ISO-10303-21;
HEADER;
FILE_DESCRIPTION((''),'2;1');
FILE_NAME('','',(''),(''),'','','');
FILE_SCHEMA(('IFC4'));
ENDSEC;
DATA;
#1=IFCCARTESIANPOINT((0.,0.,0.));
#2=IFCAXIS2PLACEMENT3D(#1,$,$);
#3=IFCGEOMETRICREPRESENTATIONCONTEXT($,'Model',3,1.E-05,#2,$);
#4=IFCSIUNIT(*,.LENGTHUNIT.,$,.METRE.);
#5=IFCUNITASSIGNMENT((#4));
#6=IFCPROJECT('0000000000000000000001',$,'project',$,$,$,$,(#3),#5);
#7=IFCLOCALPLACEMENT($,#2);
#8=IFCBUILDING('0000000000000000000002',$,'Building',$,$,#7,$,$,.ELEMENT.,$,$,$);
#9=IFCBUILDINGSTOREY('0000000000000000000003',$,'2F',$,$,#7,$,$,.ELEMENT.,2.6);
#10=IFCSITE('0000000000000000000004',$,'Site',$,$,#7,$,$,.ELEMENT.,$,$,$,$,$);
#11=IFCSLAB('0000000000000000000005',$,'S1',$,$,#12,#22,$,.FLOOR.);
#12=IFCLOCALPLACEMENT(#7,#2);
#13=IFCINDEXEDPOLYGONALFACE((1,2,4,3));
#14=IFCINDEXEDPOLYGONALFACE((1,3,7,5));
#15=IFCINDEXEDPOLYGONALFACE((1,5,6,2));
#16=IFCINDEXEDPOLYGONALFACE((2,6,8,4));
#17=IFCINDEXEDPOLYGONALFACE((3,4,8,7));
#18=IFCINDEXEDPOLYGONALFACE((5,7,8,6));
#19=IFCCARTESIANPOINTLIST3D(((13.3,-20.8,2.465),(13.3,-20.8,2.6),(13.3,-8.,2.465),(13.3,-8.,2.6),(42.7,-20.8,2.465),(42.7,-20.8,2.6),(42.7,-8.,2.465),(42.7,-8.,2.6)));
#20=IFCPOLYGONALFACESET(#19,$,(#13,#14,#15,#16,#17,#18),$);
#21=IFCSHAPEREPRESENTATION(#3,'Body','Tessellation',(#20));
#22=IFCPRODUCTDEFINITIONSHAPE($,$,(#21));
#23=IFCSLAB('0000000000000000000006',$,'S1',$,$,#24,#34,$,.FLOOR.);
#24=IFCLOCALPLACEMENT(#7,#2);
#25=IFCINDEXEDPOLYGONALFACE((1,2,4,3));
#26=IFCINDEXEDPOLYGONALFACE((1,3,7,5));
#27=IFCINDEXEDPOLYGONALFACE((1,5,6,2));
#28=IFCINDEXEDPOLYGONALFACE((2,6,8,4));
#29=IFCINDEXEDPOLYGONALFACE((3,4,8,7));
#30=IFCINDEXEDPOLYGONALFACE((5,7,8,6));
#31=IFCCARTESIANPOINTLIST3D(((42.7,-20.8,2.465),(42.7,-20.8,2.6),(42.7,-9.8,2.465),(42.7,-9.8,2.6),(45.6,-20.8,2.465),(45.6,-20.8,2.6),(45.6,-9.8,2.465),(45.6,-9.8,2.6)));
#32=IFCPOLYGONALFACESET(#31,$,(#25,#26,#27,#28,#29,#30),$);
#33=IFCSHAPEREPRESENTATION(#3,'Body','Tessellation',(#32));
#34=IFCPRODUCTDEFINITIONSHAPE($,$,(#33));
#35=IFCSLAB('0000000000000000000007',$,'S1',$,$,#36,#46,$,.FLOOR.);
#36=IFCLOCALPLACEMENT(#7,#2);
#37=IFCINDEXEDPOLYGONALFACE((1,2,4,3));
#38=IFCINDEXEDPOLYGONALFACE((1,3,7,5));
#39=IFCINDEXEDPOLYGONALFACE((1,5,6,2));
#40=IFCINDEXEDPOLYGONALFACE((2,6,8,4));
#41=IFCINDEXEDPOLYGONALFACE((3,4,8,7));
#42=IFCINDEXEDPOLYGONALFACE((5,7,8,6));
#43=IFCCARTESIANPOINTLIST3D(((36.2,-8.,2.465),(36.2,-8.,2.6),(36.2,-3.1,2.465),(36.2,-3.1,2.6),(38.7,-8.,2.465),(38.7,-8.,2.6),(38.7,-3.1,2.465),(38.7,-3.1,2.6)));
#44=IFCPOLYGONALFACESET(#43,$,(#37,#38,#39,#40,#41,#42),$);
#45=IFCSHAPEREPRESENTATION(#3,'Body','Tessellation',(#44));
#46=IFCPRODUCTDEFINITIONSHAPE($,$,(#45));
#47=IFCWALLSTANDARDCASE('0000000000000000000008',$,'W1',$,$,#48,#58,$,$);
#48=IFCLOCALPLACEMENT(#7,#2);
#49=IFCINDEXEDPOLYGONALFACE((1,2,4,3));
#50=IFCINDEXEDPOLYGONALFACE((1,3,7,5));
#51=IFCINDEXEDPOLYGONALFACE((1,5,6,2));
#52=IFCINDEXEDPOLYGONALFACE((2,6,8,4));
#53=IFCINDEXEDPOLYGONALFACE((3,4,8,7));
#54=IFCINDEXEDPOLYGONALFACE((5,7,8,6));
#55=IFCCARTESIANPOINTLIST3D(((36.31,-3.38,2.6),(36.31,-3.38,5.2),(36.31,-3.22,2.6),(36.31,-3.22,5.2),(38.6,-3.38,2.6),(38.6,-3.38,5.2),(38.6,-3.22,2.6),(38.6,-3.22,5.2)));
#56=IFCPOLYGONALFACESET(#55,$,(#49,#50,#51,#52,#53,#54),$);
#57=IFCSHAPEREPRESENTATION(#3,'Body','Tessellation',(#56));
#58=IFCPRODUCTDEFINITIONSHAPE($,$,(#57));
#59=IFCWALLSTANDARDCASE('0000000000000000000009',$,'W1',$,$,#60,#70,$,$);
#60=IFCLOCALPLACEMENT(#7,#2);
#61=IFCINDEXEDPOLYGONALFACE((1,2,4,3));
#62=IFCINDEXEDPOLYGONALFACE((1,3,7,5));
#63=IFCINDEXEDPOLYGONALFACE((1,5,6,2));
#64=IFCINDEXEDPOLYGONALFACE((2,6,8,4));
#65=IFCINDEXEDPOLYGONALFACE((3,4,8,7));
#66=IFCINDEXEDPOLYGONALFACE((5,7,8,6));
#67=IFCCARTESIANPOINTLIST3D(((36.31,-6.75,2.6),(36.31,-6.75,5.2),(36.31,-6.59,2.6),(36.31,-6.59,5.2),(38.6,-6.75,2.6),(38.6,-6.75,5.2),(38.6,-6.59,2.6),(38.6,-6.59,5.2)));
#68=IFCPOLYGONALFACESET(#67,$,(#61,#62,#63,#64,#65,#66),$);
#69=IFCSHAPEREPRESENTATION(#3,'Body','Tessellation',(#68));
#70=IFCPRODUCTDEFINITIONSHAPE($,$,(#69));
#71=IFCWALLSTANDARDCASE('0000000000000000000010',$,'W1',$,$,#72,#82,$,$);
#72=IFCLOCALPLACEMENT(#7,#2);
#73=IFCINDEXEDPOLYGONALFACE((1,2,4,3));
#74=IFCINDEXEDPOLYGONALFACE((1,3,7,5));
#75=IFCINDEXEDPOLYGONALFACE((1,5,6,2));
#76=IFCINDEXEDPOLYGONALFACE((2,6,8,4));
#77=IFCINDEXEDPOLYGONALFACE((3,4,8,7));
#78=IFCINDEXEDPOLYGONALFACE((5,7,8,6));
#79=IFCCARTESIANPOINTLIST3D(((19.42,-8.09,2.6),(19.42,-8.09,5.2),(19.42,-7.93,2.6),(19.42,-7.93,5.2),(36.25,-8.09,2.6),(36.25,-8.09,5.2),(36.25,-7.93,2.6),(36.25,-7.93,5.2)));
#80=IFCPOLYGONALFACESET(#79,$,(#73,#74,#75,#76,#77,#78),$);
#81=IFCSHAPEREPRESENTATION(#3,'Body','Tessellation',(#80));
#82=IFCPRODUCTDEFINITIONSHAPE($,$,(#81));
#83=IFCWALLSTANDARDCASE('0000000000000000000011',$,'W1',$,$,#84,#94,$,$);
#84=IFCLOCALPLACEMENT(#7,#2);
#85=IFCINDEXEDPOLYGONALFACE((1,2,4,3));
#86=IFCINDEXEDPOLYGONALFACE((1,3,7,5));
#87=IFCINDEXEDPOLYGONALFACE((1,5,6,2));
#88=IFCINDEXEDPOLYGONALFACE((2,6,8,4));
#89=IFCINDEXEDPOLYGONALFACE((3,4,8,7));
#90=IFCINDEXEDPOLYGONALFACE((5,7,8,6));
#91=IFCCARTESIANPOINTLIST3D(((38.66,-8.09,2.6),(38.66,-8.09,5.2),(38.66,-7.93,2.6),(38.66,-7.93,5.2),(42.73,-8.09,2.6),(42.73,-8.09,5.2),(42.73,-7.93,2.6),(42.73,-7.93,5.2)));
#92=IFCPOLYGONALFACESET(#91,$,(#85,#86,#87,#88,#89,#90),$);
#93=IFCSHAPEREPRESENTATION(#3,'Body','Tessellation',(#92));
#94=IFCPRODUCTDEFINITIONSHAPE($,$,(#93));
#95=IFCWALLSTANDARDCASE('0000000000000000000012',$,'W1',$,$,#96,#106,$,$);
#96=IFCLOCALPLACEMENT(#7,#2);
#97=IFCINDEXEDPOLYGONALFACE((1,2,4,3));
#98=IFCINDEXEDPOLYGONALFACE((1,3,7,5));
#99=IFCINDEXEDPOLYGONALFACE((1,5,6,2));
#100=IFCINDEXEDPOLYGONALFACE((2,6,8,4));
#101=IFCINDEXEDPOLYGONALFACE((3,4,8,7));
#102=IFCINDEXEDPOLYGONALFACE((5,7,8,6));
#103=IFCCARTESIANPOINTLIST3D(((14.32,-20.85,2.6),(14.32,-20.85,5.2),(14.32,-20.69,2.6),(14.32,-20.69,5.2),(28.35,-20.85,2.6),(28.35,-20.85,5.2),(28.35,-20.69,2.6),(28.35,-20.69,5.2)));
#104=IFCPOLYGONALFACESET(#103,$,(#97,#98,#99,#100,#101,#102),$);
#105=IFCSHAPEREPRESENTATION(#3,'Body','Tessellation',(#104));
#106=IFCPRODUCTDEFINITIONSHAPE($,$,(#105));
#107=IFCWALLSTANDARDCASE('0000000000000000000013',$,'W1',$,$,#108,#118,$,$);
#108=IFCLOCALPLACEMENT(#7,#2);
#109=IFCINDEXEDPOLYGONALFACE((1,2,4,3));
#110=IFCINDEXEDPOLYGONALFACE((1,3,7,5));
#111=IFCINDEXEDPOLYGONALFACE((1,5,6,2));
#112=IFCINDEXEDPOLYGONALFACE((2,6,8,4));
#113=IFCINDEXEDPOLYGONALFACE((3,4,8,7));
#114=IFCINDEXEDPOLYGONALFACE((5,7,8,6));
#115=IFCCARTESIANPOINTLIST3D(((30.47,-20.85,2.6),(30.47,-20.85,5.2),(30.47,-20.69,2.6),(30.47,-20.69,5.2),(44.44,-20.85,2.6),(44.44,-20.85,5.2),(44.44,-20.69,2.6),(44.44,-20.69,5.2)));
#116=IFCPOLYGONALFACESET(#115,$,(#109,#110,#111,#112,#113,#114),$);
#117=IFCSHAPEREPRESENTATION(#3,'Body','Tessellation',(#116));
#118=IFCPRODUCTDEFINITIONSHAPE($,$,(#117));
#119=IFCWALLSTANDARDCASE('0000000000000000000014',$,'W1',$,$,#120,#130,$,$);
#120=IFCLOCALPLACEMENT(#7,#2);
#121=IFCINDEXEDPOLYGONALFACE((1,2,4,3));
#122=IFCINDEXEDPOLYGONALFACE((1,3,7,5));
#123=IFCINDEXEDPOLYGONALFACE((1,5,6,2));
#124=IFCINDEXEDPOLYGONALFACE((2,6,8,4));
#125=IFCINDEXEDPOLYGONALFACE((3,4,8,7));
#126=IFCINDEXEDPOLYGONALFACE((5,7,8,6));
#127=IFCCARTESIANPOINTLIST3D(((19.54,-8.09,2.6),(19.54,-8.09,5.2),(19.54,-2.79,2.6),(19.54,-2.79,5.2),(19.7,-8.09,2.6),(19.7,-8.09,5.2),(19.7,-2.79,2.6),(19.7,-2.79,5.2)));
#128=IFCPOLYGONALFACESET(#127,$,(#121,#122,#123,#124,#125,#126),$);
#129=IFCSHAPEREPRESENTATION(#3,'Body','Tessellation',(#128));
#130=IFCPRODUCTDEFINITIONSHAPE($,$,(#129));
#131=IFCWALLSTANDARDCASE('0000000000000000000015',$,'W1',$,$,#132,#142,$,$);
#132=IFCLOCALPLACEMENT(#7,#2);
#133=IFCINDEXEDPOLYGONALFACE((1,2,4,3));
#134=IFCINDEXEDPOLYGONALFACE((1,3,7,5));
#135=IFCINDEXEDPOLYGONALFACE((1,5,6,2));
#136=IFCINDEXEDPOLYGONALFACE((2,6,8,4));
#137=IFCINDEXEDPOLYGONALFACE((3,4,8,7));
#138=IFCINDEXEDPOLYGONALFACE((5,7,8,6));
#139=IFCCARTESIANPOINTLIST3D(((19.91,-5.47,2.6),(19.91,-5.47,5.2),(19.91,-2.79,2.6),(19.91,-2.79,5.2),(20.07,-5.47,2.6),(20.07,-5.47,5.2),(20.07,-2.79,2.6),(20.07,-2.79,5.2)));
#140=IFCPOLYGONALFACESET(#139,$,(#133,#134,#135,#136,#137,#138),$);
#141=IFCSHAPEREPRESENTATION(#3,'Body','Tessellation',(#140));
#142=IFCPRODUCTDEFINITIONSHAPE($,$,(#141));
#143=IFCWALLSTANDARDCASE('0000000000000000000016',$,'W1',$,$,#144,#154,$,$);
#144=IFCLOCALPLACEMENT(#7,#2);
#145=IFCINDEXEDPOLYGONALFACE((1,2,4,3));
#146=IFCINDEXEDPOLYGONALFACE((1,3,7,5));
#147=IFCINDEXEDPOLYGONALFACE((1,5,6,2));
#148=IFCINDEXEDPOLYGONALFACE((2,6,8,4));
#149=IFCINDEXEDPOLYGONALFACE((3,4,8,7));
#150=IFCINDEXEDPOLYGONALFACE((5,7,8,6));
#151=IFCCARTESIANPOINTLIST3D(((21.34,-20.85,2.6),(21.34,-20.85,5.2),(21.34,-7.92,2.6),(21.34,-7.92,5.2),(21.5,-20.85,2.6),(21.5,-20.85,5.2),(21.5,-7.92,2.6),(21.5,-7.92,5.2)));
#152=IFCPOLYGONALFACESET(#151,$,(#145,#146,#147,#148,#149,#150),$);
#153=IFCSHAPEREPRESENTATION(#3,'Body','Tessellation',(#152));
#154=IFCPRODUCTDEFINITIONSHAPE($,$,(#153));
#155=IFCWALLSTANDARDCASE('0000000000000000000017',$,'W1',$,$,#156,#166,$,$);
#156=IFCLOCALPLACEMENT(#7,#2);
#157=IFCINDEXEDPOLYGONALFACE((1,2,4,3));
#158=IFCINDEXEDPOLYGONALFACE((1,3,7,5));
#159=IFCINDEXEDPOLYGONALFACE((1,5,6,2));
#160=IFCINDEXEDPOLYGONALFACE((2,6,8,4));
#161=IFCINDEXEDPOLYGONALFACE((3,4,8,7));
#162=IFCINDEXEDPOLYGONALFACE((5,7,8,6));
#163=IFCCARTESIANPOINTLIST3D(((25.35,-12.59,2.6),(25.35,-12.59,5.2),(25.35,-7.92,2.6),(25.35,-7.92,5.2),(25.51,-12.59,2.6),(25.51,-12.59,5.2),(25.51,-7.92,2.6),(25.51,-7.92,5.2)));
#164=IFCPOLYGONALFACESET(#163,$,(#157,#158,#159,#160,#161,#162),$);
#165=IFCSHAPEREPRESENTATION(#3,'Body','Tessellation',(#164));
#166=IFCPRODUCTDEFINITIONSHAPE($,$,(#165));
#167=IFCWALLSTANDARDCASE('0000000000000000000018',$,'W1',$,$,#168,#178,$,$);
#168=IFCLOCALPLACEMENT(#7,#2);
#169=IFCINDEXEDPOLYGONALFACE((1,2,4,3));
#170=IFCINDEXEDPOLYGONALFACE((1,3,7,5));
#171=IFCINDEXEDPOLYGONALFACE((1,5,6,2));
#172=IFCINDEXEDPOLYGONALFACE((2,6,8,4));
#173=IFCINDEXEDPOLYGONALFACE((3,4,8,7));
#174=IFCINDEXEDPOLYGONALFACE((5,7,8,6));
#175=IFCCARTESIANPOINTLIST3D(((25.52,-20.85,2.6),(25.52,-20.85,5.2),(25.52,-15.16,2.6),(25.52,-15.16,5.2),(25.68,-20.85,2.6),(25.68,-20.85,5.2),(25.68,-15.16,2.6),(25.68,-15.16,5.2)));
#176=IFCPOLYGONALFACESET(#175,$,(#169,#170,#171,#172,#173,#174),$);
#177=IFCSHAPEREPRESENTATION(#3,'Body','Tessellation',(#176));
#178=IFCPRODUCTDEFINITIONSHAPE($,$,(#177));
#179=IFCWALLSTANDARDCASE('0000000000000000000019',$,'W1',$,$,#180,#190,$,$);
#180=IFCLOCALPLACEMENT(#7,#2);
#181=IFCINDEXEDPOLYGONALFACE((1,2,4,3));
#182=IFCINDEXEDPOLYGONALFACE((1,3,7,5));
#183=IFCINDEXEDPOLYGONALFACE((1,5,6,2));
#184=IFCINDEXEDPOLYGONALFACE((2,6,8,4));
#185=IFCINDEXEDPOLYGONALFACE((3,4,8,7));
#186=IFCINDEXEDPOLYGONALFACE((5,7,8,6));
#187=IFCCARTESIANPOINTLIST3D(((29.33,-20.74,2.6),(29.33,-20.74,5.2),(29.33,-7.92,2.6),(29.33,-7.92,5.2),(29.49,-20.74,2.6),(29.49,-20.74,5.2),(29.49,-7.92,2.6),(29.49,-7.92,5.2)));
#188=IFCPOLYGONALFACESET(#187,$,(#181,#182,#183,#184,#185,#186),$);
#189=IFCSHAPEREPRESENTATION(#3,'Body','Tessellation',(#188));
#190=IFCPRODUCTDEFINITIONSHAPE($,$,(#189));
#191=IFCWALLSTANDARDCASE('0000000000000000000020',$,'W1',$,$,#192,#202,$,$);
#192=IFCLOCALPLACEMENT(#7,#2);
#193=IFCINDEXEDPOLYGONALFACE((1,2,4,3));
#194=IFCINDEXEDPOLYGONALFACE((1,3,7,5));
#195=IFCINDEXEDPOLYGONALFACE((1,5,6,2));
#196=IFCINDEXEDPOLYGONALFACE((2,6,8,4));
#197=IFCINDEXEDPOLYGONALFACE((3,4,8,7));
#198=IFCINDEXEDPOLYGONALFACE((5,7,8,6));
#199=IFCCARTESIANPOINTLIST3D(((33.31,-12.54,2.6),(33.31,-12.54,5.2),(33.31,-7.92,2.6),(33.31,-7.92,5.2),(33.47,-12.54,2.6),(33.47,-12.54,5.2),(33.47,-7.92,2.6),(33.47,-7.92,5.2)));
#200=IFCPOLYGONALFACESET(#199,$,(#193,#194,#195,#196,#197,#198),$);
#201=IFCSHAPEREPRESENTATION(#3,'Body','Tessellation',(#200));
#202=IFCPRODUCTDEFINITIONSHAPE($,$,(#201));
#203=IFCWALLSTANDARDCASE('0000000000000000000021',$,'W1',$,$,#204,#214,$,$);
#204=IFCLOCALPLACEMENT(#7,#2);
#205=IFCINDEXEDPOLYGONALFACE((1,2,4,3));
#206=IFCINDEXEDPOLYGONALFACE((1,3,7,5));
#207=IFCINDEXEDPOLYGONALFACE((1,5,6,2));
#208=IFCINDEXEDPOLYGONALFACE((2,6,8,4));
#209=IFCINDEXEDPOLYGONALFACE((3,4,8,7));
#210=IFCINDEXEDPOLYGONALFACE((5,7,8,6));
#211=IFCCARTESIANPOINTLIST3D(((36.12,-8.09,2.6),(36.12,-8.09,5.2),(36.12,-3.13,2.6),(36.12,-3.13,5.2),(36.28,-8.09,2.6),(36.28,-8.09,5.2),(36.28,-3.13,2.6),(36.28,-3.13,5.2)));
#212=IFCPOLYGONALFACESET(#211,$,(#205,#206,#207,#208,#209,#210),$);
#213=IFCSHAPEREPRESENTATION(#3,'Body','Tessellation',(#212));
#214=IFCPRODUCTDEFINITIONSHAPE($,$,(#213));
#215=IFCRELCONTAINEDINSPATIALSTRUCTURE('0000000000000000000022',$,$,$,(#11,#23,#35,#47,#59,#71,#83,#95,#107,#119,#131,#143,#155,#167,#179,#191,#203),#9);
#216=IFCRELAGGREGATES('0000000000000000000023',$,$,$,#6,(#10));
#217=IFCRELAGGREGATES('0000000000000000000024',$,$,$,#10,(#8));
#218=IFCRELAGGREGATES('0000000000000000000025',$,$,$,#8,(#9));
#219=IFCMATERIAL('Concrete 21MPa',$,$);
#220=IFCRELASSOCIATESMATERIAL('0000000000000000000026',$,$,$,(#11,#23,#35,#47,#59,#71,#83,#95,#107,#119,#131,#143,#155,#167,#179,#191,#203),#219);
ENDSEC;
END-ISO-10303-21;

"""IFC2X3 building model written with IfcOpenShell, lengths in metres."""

from ifc_helpers import new_model, si_unit, frame, origin, origin_2d, place, context, project, spatial, rectangle, extrude, material, element, save


model = new_model("IFC2X3")

# Units and contexts
model_context = context("Model", 3, precision=1e-05, world=origin())
ifc_project = project(units=[si_unit("LENGTHUNIT", "METRE")], contexts=[model_context])

# Site, building, storey
placement = place(None, origin())
site = spatial("IfcSite", under=ifc_project, at=placement, Name="Site", CompositionType="ELEMENT")
building = spatial("IfcBuilding", under=site, at=placement, Name="Building", CompositionType="ELEMENT")
storey = spatial("IfcBuildingStorey", under=building, at=placement, Name="2F", CompositionType="ELEMENT", Elevation=2.6)

# Slabs
ifc_material_1 = material(Name="Concrete 21MPa")
slab_1_placement = place(None, frame((28.0, -14.4, 2.465)))
element("IfcSlab", 1, at=slab_1_placement, inside=storey, material=ifc_material_1, Name="S1", PredefinedType="FLOOR", context=model_context, shape_type="SweptSolid", body=[
    extrude(rectangle(XDim=29.4, YDim=12.8, at=origin_2d()), origin(), (0.0, 0.0, 1.0), 0.135),
])
slab_2_placement = place(None, frame((44.15, -15.3, 2.465)))
element("IfcSlab", 2, at=slab_2_placement, inside=storey, material=ifc_material_1, Name="S1", PredefinedType="FLOOR", context=model_context, shape_type="SweptSolid", body=[
    extrude(rectangle(XDim=2.9, YDim=11.0, at=origin_2d()), origin(), (0.0, 0.0, 1.0), 0.135),
])
slab_3_placement = place(None, frame((37.45, -5.55, 2.465)))
element("IfcSlab", 3, at=slab_3_placement, inside=storey, material=ifc_material_1, Name="S1", PredefinedType="FLOOR", context=model_context, shape_type="SweptSolid", body=[
    extrude(rectangle(XDim=2.5, YDim=4.9, at=origin_2d()), origin(), (0.0, 0.0, 1.0), 0.135),
])

# Walls
for number, where, name in (
    (4, (37.455, -3.3, 2.6), "W1"),
    (5, (37.455, -6.67, 2.6), "W1"),
):
    element("IfcWallStandardCase", number, at=place(None, frame(where)), inside=storey, material=ifc_material_1, Name=name, context=model_context, shape_type="SweptSolid", body=[
        extrude(rectangle(XDim=2.29, YDim=0.16, at=origin_2d()), origin(), (0.0, 0.0, 1.0), 2.6),
    ])
wall_1_placement = place(None, frame((27.835, -8.01, 2.6)))
element("IfcWallStandardCase", 6, at=wall_1_placement, inside=storey, material=ifc_material_1, Name="W1", context=model_context, shape_type="SweptSolid", body=[
    extrude(rectangle(XDim=16.83, YDim=0.16, at=origin_2d()), origin(), (0.0, 0.0, 1.0), 2.6),
])
wall_2_placement = place(None, frame((40.695, -8.01, 2.6)))
element("IfcWallStandardCase", 7, at=wall_2_placement, inside=storey, material=ifc_material_1, Name="W1", context=model_context, shape_type="SweptSolid", body=[
    extrude(rectangle(XDim=4.07, YDim=0.16, at=origin_2d()), origin(), (0.0, 0.0, 1.0), 2.6),
])
wall_3_placement = place(None, frame((21.335, -20.77, 2.6)))
element("IfcWallStandardCase", 8, at=wall_3_placement, inside=storey, material=ifc_material_1, Name="W1", context=model_context, shape_type="SweptSolid", body=[
    extrude(rectangle(XDim=14.03, YDim=0.16, at=origin_2d()), origin(), (0.0, 0.0, 1.0), 2.6),
])
wall_4_placement = place(None, frame((37.455, -20.77, 2.6)))
element("IfcWallStandardCase", 9, at=wall_4_placement, inside=storey, material=ifc_material_1, Name="W1", context=model_context, shape_type="SweptSolid", body=[
    extrude(rectangle(XDim=13.97, YDim=0.16, at=origin_2d()), origin(), (0.0, 0.0, 1.0), 2.6),
])
wall_5_placement = place(None, frame((19.62, -5.44, 2.6)))
element("IfcWallStandardCase", 10, at=wall_5_placement, inside=storey, material=ifc_material_1, Name="W1", context=model_context, shape_type="SweptSolid", body=[
    extrude(rectangle(XDim=0.16, YDim=5.3, at=origin_2d()), origin(), (0.0, 0.0, 1.0), 2.6),
])
wall_6_placement = place(None, frame((19.99, -4.13, 2.6)))
element("IfcWallStandardCase", 11, at=wall_6_placement, inside=storey, material=ifc_material_1, Name="W1", context=model_context, shape_type="SweptSolid", body=[
    extrude(rectangle(XDim=0.16, YDim=2.68, at=origin_2d()), origin(), (0.0, 0.0, 1.0), 2.6),
])
wall_7_placement = place(None, frame((21.42, -14.385, 2.6)))
element("IfcWallStandardCase", 12, at=wall_7_placement, inside=storey, material=ifc_material_1, Name="W1", context=model_context, shape_type="SweptSolid", body=[
    extrude(rectangle(XDim=0.16, YDim=12.93, at=origin_2d()), origin(), (0.0, 0.0, 1.0), 2.6),
])
wall_8_placement = place(None, frame((25.43, -10.255, 2.6)))
element("IfcWallStandardCase", 13, at=wall_8_placement, inside=storey, material=ifc_material_1, Name="W1", context=model_context, shape_type="SweptSolid", body=[
    extrude(rectangle(XDim=0.16, YDim=4.67, at=origin_2d()), origin(), (0.0, 0.0, 1.0), 2.6),
])
wall_9_placement = place(None, frame((25.6, -18.005, 2.6)))
element("IfcWallStandardCase", 14, at=wall_9_placement, inside=storey, material=ifc_material_1, Name="W1", context=model_context, shape_type="SweptSolid", body=[
    extrude(rectangle(XDim=0.16, YDim=5.69, at=origin_2d()), origin(), (0.0, 0.0, 1.0), 2.6),
])
wall_10_placement = place(None, frame((29.41, -14.33, 2.6)))
element("IfcWallStandardCase", 15, at=wall_10_placement, inside=storey, material=ifc_material_1, Name="W1", context=model_context, shape_type="SweptSolid", body=[
    extrude(rectangle(XDim=0.16, YDim=12.82, at=origin_2d()), origin(), (0.0, 0.0, 1.0), 2.6),
])
wall_11_placement = place(None, frame((33.39, -10.23, 2.6)))
element("IfcWallStandardCase", 16, at=wall_11_placement, inside=storey, material=ifc_material_1, Name="W1", context=model_context, shape_type="SweptSolid", body=[
    extrude(rectangle(XDim=0.16, YDim=4.62, at=origin_2d()), origin(), (0.0, 0.0, 1.0), 2.6),
])
wall_12_placement = place(None, frame((36.2, -5.61, 2.6)))
element("IfcWallStandardCase", 17, at=wall_12_placement, inside=storey, material=ifc_material_1, Name="W1", context=model_context, shape_type="SweptSolid", body=[
    extrude(rectangle(XDim=0.16, YDim=4.96, at=origin_2d()), origin(), (0.0, 0.0, 1.0), 2.6),
])

save(model, "model.ifc")
